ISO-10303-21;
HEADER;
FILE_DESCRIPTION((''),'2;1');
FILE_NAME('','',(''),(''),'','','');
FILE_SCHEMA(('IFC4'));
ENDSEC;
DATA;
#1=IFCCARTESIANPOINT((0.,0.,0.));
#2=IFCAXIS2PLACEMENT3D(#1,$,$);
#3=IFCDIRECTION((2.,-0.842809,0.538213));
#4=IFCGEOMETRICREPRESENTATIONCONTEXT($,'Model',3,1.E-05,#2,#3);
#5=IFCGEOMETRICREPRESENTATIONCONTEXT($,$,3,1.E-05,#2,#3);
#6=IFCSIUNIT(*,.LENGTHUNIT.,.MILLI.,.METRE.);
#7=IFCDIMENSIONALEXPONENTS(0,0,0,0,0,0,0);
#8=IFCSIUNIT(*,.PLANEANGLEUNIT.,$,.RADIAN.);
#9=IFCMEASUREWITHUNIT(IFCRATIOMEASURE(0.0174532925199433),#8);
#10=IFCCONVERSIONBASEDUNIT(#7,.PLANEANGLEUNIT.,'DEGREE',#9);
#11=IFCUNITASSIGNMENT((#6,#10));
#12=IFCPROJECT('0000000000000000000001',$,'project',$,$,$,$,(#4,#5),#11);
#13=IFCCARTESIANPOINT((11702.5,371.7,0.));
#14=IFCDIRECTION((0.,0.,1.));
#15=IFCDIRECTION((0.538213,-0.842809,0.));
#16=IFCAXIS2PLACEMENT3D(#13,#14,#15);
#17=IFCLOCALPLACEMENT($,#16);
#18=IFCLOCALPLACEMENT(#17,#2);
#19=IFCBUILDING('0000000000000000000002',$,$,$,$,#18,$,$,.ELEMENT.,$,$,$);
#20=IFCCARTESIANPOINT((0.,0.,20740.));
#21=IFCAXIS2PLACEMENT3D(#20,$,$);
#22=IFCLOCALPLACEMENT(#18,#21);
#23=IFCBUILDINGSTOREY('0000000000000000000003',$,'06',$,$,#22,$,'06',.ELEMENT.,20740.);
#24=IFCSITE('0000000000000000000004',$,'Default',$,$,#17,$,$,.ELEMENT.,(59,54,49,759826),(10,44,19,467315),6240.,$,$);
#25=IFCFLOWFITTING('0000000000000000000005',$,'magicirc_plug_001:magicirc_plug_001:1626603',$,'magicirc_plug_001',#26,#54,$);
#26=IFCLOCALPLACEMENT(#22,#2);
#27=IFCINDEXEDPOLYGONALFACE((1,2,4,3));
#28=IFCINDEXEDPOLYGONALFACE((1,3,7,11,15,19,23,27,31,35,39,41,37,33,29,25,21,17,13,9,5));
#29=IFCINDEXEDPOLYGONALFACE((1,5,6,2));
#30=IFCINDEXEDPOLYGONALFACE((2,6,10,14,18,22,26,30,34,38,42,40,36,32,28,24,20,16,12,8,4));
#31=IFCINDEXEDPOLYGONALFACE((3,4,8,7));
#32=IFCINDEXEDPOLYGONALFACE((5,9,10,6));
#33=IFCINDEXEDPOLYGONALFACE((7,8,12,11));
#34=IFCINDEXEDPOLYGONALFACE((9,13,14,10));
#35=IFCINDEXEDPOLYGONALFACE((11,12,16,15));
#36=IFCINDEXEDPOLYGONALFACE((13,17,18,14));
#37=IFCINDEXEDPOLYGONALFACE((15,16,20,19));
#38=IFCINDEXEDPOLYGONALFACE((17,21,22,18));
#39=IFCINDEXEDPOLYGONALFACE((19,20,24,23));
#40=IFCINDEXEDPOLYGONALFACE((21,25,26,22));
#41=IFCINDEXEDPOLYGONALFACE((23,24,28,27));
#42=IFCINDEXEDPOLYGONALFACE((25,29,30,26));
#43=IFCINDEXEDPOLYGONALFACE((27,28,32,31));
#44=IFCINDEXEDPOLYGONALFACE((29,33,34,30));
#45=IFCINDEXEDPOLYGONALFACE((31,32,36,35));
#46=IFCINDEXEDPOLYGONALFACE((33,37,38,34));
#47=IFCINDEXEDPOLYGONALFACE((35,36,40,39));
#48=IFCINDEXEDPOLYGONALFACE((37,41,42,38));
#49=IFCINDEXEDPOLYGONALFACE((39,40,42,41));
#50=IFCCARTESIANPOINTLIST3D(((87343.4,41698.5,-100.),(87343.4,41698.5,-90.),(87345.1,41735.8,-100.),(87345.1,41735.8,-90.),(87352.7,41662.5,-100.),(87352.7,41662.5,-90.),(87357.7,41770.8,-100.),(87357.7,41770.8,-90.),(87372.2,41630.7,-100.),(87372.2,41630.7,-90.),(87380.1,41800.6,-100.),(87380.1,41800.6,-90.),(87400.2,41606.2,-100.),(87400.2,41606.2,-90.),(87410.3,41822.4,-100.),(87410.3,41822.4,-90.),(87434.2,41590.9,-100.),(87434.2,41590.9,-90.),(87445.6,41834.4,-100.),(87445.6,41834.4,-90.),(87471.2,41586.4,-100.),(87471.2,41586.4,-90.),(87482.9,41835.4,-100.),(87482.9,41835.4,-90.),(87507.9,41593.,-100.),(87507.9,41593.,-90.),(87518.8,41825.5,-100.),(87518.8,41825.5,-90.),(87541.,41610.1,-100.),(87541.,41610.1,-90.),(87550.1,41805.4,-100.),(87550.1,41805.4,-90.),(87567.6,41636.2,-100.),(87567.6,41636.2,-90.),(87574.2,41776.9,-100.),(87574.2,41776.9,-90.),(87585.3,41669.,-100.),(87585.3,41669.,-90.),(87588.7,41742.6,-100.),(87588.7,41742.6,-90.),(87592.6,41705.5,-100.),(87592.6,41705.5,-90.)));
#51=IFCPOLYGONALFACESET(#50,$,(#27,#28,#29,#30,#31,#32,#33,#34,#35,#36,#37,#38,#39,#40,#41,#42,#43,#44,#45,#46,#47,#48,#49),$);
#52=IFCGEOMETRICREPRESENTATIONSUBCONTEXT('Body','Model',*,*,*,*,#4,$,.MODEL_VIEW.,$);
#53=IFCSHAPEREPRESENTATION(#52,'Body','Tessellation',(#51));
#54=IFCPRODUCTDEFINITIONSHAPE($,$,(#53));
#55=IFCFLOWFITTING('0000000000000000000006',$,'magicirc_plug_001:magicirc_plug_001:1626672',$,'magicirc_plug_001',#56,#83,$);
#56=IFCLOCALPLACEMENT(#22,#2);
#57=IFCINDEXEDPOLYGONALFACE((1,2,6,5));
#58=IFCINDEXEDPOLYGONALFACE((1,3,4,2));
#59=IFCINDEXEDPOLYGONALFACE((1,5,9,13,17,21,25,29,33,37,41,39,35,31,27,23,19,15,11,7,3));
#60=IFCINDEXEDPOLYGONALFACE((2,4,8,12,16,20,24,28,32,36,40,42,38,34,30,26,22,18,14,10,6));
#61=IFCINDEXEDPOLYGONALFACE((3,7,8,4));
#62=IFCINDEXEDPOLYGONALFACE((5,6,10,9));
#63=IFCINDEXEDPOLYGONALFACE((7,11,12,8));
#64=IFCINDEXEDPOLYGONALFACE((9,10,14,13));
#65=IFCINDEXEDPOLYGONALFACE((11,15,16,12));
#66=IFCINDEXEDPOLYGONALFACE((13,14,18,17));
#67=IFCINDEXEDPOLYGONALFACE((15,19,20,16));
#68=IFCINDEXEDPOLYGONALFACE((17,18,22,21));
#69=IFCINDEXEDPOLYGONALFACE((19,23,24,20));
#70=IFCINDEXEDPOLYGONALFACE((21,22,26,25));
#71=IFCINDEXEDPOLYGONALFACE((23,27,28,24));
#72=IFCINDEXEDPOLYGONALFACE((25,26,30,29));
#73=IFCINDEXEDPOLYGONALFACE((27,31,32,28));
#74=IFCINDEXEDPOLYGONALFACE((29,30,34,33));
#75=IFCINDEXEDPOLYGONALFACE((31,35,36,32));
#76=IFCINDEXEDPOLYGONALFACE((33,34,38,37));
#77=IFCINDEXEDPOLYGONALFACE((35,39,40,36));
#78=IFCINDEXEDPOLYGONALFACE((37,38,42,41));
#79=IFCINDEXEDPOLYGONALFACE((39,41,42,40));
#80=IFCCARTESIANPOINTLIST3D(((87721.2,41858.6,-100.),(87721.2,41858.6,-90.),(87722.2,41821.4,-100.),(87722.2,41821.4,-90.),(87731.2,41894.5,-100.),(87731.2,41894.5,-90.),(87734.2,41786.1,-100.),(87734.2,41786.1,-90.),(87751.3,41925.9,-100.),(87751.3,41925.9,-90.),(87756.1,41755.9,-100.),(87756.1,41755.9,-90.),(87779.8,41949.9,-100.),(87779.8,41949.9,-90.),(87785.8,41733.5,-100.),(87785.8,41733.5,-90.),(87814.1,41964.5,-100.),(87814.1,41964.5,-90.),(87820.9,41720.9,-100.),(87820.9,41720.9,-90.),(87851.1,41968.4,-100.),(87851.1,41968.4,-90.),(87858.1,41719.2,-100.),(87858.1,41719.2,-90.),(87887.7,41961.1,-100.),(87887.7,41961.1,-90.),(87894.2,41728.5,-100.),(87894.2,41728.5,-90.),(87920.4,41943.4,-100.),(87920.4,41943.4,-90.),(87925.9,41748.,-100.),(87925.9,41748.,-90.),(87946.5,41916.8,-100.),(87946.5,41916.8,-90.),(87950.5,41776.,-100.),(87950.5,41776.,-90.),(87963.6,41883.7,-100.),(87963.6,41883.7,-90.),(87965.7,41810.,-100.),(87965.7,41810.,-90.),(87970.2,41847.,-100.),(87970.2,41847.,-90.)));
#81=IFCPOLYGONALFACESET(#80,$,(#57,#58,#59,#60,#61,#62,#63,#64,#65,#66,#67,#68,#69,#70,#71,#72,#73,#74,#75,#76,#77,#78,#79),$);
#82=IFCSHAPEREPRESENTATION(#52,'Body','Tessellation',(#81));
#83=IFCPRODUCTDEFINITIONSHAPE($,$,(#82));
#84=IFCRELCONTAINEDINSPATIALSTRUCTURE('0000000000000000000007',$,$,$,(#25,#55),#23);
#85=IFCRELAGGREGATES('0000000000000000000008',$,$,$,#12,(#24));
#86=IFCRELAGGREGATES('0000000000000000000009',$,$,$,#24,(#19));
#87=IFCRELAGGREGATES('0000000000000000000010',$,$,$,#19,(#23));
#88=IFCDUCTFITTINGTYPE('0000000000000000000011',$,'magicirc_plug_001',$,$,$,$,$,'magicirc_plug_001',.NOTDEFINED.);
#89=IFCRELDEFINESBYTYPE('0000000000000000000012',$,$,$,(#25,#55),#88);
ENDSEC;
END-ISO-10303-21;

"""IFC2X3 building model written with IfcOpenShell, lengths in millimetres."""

from ifc_helpers import new_model, entity, si_unit, converted_unit, direction, frame, frame_2d, origin, place, context, subcontext, project, spatial, circle, extrude, source, transform, mapped, type_object, type_shapes, element, save


model = new_model("IFC2X3")

# Units and contexts
model_context = context("Model", 3, precision=1e-05, world=origin(), true_north=direction((2.0, -0.842809, 0.538213)))
context_of_model = context(None, 3, precision=1e-05, world=origin(), true_north=direction((2.0, -0.842809, 0.538213)))
body_context = subcontext(model_context, "Body", "Model", "MODEL_VIEW")
ifc_project = project(units=[si_unit("LENGTHUNIT", "METRE", prefix="MILLI"), converted_unit("PLANEANGLEUNIT", "DEGREE", entity("IfcRatioMeasure", 0.0174532925199433), si_unit("PLANEANGLEUNIT", "RADIAN"), dimensions=[0, 0, 0, 0, 0, 0, 0])], contexts=[model_context, context_of_model])

# Site, building, storey
site_placement = place(None, frame((11702.5, 371.7, 0.0), z_axis=(0.0, 0.0, 1.0), x_axis=(0.538213, -0.842809, 0.0)))
site = spatial("IfcSite", under=ifc_project, at=site_placement, Name="Default", CompositionType="ELEMENT", RefLatitude=(59, 54, 49, 759826), RefLongitude=(10, 44, 19, 467315), RefElevation=6240.0)
building_placement = place(site_placement, origin())
building = spatial("IfcBuilding", under=site, at=building_placement, CompositionType="ELEMENT")
storey_placement = place(building_placement, frame((0.0, 0.0, 20740.0)))
storey = spatial("IfcBuildingStorey", under=building, at=storey_placement, Name="06", LongName="06", CompositionType="ELEMENT", Elevation=20740.0)

# Flow fittings
duct_fitting_type = type_object("IfcDuctFittingType", Name="magicirc_plug_001", ElementType="magicirc_plug_001", PredefinedType="NOTDEFINED")
shared_shape = source(origin(), body_context, "Body", "SweptSolid", [
    extrude(circle(Radius=125.0, at=frame_2d((0.0, 0.0), x_axis=(1.0, 0.0))), frame((0.0, 0.0, 0.0), z_axis=(1.0, 0.0, 0.0), x_axis=(0.0, 1.0, 0.0)), (0.0, 0.0, 1.0), 10.0),
])
type_shapes(duct_fitting_type, [shared_shape])
for number, where, z_axis, x_axis, name in (
    (1, (87467.7, 41711.4, -100.0), (0.94693, 0.321439, 0.0), (0.0, 0.0, 1.0), "magicirc_plug_001:magicirc_plug_001:1626603"),
    (2, (87845.3, 41843.5, -100.0), (-0.321439, 0.94693, 0.0), (0.0, 0.0, 1.0), "magicirc_plug_001:magicirc_plug_001:1626672"),
):
    element("IfcFlowFitting", number, at=place(storey_placement, frame(where, z_axis=z_axis, x_axis=x_axis)), inside=storey, type_object=duct_fitting_type, Name=name, ObjectType="magicirc_plug_001", context=body_context, shape_type="MappedRepresentation", body=[
        mapped(shared_shape, transform((0.0, 0.0, 0.0), scale=1.0)),
    ])

save(model, "model.ifc")
